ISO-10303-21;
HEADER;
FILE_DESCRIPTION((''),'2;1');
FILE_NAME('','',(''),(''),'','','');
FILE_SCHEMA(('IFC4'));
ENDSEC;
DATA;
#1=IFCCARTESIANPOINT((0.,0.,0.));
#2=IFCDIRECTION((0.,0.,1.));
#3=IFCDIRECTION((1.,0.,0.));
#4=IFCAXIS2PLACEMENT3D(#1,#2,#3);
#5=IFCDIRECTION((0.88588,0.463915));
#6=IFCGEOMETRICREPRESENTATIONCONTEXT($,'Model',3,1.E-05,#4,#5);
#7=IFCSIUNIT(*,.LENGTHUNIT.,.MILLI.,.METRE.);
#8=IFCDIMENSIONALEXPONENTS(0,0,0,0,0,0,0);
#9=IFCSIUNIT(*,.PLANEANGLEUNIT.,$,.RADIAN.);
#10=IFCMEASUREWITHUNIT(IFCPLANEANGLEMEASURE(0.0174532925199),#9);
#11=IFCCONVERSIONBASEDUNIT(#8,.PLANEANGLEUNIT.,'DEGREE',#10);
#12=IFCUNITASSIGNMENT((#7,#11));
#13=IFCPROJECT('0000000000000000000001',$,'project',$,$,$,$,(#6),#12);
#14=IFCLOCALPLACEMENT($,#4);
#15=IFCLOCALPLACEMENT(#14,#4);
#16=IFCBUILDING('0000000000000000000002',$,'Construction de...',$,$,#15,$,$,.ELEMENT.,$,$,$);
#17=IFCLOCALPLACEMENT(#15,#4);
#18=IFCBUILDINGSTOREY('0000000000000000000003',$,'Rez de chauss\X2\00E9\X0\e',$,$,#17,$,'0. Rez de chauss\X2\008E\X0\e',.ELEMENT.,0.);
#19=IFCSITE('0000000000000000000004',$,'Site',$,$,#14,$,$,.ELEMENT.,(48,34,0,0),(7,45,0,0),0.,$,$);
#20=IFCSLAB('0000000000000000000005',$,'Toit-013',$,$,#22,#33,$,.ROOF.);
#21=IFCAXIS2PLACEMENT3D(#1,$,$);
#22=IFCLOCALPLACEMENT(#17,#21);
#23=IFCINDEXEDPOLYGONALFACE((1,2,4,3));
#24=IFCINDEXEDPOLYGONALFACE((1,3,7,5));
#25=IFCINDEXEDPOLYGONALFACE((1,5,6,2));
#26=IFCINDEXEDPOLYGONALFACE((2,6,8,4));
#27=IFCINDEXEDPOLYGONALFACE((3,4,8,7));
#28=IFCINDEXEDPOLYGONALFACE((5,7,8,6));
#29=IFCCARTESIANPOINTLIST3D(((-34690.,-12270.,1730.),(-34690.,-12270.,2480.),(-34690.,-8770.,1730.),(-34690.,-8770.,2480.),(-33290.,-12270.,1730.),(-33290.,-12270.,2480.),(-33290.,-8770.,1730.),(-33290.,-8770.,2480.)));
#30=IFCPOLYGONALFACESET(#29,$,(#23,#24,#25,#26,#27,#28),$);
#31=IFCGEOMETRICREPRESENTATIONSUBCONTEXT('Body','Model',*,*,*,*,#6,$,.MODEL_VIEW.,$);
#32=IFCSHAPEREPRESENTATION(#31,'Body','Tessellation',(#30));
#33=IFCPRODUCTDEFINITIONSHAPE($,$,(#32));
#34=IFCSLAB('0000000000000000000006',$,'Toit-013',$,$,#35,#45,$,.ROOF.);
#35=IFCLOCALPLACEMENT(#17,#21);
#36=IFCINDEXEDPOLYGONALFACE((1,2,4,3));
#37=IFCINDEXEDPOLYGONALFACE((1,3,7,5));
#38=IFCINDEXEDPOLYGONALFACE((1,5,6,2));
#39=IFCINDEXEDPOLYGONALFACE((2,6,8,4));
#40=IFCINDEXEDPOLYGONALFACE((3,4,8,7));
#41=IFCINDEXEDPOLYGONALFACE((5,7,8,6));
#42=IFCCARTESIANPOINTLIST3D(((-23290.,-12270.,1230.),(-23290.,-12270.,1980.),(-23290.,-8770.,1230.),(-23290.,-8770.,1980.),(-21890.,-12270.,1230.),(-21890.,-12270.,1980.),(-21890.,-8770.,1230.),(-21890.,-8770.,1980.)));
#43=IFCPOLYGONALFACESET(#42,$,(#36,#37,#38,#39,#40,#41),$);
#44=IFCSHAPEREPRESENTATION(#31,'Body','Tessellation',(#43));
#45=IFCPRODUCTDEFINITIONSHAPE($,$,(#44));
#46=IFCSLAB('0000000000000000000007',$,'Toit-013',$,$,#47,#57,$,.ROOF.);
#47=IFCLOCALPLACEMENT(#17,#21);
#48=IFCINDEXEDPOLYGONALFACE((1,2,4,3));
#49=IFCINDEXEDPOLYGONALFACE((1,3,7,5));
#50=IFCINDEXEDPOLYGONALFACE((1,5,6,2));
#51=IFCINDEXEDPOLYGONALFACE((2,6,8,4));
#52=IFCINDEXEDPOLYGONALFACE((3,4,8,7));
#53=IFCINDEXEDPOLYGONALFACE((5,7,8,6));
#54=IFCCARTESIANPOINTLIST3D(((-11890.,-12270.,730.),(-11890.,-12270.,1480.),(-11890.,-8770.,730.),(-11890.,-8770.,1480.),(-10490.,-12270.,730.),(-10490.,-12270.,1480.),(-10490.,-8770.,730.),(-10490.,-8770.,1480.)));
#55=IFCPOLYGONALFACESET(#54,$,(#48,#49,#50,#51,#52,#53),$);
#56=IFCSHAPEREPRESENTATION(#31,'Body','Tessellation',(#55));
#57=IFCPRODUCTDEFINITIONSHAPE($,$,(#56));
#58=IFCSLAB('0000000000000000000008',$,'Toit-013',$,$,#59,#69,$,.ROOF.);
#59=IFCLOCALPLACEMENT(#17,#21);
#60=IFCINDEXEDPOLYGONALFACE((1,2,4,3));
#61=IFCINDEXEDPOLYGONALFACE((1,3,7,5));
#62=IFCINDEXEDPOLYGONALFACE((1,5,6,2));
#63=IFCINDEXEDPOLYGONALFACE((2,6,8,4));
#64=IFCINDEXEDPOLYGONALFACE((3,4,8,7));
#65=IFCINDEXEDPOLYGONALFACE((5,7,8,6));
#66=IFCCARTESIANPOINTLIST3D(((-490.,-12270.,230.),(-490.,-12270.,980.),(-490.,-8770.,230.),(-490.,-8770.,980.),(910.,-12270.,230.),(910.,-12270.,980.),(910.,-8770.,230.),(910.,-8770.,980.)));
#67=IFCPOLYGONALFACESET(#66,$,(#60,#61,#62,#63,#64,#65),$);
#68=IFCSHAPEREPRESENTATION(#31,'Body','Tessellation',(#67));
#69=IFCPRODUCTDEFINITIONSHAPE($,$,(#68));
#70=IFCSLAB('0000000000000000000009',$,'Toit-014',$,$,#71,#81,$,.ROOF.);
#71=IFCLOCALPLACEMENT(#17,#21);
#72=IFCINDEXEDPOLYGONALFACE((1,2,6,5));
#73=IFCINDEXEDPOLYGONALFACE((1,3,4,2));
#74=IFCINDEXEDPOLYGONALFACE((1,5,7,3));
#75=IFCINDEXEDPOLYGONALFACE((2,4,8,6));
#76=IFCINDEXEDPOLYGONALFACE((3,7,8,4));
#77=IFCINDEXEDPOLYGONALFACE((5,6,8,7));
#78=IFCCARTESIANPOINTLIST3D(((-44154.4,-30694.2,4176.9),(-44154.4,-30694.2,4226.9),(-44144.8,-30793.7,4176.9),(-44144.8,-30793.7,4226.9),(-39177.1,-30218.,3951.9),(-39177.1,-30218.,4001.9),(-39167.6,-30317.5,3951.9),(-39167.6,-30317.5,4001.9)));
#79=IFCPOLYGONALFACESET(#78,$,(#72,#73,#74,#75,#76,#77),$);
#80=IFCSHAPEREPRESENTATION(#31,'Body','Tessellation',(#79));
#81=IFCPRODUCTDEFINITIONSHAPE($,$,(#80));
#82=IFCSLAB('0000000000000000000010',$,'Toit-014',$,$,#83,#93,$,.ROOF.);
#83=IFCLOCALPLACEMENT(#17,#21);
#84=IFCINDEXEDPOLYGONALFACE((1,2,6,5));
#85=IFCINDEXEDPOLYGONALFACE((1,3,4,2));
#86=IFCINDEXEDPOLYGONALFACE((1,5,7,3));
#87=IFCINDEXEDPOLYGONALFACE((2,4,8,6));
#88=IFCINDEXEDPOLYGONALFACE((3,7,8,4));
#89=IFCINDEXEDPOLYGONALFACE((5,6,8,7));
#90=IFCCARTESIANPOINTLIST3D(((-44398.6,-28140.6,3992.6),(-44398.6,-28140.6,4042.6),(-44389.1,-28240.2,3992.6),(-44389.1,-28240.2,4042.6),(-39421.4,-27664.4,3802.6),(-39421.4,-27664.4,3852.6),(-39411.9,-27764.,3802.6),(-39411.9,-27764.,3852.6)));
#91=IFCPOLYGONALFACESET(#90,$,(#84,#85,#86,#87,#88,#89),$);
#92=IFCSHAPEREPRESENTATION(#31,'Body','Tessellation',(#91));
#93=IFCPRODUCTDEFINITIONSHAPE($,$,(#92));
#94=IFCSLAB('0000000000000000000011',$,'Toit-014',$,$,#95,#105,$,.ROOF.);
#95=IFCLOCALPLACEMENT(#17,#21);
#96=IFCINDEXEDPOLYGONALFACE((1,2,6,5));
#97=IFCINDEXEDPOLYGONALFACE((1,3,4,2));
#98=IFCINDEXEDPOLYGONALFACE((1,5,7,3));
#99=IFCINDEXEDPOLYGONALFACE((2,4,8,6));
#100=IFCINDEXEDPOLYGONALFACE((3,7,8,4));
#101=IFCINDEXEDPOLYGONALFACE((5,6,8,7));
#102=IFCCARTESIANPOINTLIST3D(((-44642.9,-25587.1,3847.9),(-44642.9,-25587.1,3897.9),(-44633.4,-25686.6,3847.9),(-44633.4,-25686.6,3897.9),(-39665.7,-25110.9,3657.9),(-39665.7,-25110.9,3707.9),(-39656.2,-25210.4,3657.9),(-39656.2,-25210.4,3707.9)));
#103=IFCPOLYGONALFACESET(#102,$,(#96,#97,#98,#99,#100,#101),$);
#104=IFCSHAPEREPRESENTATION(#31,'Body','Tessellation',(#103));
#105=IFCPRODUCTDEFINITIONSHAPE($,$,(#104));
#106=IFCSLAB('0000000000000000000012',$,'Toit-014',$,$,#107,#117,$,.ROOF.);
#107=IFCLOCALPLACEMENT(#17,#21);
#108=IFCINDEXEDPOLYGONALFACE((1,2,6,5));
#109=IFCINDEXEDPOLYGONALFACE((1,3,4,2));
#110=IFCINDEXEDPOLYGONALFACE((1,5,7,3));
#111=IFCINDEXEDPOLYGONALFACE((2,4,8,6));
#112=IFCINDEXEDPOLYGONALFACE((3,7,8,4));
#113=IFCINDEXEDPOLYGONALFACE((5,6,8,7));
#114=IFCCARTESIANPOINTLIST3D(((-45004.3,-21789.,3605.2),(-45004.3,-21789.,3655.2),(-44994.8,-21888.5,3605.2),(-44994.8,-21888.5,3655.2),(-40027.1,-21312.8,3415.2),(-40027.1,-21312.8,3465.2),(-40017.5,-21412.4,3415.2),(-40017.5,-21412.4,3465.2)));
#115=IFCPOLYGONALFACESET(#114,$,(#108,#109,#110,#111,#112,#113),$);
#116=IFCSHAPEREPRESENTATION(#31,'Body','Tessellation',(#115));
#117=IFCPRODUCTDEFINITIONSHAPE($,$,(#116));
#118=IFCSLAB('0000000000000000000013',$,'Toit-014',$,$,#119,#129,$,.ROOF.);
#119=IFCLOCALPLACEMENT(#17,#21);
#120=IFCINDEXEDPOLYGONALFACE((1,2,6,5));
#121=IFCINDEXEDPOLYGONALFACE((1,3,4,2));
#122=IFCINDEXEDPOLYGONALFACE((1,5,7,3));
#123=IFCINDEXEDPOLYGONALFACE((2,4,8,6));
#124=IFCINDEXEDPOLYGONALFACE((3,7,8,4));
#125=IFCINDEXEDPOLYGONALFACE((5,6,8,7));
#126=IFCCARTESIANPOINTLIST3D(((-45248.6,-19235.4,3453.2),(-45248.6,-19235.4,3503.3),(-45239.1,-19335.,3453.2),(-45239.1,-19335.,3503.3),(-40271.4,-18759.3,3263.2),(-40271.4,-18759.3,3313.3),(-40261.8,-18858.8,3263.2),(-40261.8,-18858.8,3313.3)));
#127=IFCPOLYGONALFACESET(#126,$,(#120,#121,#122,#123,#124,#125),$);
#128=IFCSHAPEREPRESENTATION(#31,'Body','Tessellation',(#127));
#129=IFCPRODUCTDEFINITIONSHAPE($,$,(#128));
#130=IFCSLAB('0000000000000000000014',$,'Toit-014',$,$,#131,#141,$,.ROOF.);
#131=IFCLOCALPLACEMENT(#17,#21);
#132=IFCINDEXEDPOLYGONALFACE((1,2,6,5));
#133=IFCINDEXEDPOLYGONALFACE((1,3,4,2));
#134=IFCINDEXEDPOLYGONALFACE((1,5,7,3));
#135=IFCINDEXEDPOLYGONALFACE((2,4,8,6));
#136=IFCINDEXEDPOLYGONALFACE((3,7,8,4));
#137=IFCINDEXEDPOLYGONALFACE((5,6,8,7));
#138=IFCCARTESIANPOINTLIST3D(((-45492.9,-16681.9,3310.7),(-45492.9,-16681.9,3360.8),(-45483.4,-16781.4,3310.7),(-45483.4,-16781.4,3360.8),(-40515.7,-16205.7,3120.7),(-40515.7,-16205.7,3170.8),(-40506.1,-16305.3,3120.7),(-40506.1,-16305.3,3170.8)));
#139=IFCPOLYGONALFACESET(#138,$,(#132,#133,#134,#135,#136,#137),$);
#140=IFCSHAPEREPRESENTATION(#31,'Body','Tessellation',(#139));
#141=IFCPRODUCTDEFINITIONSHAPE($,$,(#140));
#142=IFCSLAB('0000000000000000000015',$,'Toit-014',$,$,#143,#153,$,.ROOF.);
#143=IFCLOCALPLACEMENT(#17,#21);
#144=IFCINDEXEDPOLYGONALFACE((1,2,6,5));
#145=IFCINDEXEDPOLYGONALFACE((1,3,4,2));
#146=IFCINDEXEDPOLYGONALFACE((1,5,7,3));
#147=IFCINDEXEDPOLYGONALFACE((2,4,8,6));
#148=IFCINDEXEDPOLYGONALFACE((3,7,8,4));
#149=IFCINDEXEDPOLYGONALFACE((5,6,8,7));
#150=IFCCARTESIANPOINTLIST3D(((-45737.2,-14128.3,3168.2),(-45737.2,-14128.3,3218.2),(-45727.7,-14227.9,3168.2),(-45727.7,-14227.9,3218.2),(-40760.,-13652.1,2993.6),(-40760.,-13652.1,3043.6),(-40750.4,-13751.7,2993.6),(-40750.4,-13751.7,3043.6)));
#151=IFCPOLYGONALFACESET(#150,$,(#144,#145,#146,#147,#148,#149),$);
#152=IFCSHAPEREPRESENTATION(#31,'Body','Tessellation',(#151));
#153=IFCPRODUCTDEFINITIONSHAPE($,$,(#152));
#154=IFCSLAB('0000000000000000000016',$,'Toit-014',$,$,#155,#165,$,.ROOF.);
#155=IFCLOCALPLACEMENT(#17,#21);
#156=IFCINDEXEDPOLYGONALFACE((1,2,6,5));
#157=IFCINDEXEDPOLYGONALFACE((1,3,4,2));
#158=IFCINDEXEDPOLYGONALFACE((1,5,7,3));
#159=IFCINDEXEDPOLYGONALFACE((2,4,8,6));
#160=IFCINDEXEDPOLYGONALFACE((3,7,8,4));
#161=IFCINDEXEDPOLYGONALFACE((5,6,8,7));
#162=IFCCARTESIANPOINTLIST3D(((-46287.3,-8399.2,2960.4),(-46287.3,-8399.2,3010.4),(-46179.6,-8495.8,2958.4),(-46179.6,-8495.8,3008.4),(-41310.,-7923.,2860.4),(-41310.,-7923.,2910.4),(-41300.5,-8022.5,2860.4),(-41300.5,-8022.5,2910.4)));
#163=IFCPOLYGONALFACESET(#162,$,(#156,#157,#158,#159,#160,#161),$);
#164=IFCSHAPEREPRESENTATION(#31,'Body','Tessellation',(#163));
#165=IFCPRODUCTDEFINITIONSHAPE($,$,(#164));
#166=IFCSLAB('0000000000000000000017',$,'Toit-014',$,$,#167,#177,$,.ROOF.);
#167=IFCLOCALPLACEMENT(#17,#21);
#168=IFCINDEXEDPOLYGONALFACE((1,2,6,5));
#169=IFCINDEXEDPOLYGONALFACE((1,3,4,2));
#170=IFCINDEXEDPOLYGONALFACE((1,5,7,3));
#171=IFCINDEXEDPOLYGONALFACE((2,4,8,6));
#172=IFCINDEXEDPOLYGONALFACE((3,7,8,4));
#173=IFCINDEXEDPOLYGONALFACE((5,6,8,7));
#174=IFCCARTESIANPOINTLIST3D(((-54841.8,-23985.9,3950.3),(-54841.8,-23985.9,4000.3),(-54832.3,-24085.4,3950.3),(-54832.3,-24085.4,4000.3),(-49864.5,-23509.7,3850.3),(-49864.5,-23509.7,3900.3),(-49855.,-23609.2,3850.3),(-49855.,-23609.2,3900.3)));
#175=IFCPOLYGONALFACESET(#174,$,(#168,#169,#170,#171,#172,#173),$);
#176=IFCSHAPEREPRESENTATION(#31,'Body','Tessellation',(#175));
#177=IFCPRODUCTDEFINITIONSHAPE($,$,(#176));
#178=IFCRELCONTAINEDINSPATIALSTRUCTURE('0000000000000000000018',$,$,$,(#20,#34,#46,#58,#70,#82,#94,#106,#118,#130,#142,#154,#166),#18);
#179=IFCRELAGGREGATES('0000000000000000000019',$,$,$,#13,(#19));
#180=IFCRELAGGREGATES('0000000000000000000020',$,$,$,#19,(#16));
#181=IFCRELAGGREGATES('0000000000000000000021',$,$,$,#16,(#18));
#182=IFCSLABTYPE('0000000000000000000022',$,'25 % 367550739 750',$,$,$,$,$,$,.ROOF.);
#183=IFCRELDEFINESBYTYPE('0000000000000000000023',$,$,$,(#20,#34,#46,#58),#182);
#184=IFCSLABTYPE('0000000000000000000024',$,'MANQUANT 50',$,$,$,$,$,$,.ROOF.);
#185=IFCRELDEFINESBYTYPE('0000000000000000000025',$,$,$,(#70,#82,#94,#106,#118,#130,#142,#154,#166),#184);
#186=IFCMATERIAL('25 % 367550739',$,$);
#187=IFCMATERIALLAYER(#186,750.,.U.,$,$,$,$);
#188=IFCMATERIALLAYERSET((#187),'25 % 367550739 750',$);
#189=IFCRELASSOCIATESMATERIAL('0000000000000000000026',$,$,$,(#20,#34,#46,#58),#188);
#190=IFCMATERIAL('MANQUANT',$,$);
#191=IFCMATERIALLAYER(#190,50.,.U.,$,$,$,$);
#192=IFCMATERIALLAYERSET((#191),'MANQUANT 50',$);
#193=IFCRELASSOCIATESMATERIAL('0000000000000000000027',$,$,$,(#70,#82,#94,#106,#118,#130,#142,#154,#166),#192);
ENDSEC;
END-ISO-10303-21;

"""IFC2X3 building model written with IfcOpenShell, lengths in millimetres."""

from ifc_helpers import new_model, entity, si_unit, converted_unit, direction, frame, origin_with_axes, place, context, subcontext, project, spatial, polyline, outline, extrude, material, layer, layer_set, layer_usage, type_object, element, save


model = new_model("IFC2X3")

# Units and contexts
model_context = context("Model", 3, precision=1e-05, world=origin_with_axes(), true_north=direction((0.88588, 0.463915)))
body_context = subcontext(model_context, "Body", "Model", "MODEL_VIEW")
ifc_project = project(units=[si_unit("LENGTHUNIT", "METRE", prefix="MILLI"), converted_unit("PLANEANGLEUNIT", "DEGREE", entity("IfcPlaneAngleMeasure", 0.0174532925199), si_unit("PLANEANGLEUNIT", "RADIAN"), dimensions=[0, 0, 0, 0, 0, 0, 0])], contexts=[model_context])

# Site, building, storey
site_placement = place(None, origin_with_axes())
site = spatial("IfcSite", under=ifc_project, at=site_placement, Name="Site", CompositionType="ELEMENT", RefLatitude=(48, 34, 0, 0), RefLongitude=(7, 45, 0, 0), RefElevation=0.0)
building_placement = place(site_placement, origin_with_axes())
building = spatial("IfcBuilding", under=site, at=building_placement, Name="Construction de...", CompositionType="ELEMENT")
storey_placement = place(building_placement, origin_with_axes())
storey = spatial("IfcBuildingStorey", under=building, at=storey_placement, Name="Rez de chaussée", LongName="0. Rez de chauss\u008ee", CompositionType="ELEMENT", Elevation=0.0)

# Slabs
ifc_material_1 = material(Name="25 % 367550739")
ifc_layer_1 = layer(ifc_material_1, 750.0, ventilated="UNKNOWN")
ifc_layer_set_1 = layer_set([ifc_layer_1], Name="25 % 367550739 750")
ifc_layer_usage_1 = layer_usage(ifc_layer_set_1, "AXIS3", "NEGATIVE", 750.0)
slab_type_1 = type_object("IfcSlabType", Name="25 % 367550739 750", PredefinedType="ROOF")
slab_1_placement = place(storey_placement, frame((-33290.0, -8770.0, 1730.0), z_axis=(0.0, 0.0, 1.0), x_axis=(0.0, -1.0, 0.0)))
element("IfcSlab", 1, at=slab_1_placement, inside=storey, type_object=slab_type_1, material=ifc_layer_usage_1, Name="Toit-013", PredefinedType="ROOF", context=body_context, shape_type="SweptSolid", body=[
    extrude(outline(polyline([(0.0, -1400.0), (3500.0, -1400.0), (3500.0, 0.0), (0.0, 0.0), (0.0, -1400.0)])), origin_with_axes(), (0.0, 0.0, 1.0), 750.0),
])
ifc_layer_usage_2 = layer_usage(ifc_layer_set_1, "AXIS3", "NEGATIVE", 750.0)
slab_2_placement = place(storey_placement, frame((-21890.0, -8770.0, 1230.0), z_axis=(0.0, 0.0, 1.0), x_axis=(0.0, -1.0, 0.0)))
element("IfcSlab", 2, at=slab_2_placement, inside=storey, type_object=slab_type_1, material=ifc_layer_usage_2, Name="Toit-013", PredefinedType="ROOF", context=body_context, shape_type="SweptSolid", body=[
    extrude(outline(polyline([(0.0, -1400.0), (3500.0, -1400.0), (3500.0, 0.0), (0.0, 0.0), (0.0, -1400.0)])), origin_with_axes(), (0.0, 0.0, 1.0), 750.0),
])
ifc_layer_usage_3 = layer_usage(ifc_layer_set_1, "AXIS3", "NEGATIVE", 750.0)
slab_3_placement = place(storey_placement, frame((-10490.0, -8770.0, 730.0), z_axis=(0.0, 0.0, 1.0), x_axis=(0.0, -1.0, 0.0)))
element("IfcSlab", 3, at=slab_3_placement, inside=storey, type_object=slab_type_1, material=ifc_layer_usage_3, Name="Toit-013", PredefinedType="ROOF", context=body_context, shape_type="SweptSolid", body=[
    extrude(outline(polyline([(0.0, -1400.0), (3500.0, -1400.0), (3500.0, 0.0), (0.0, 0.0), (0.0, -1400.0)])), origin_with_axes(), (0.0, 0.0, 1.0), 750.0),
])
ifc_layer_usage_4 = layer_usage(ifc_layer_set_1, "AXIS3", "NEGATIVE", 750.0)
slab_4_placement = place(storey_placement, frame((910.0, -8770.0, 230.0), z_axis=(0.0, 0.0, 1.0), x_axis=(0.0, -1.0, 0.0)))
element("IfcSlab", 4, at=slab_4_placement, inside=storey, type_object=slab_type_1, material=ifc_layer_usage_4, Name="Toit-013", PredefinedType="ROOF", context=body_context, shape_type="SweptSolid", body=[
    extrude(outline(polyline([(0.0, -1400.0), (3500.0, -1400.0), (3500.0, 0.0), (0.0, 0.0), (0.0, -1400.0)])), origin_with_axes(), (0.0, 0.0, 1.0), 750.0),
])
ifc_material_2 = material(Name="MANQUANT")
ifc_layer_2 = layer(ifc_material_2, 50.0, ventilated="UNKNOWN")
ifc_layer_set_2 = layer_set([ifc_layer_2], Name="MANQUANT 50")
ifc_layer_usage_5 = layer_usage(ifc_layer_set_2, "AXIS3", "NEGATIVE", 50.0)
slab_type_2 = type_object("IfcSlabType", Name="MANQUANT 50", PredefinedType="ROOF")
slab_5_placement = place(storey_placement, frame((-39167.6, -30317.5, 3951.9), z_axis=(0.0, 0.0, 1.0), x_axis=(-0.095235, 0.995455, 0.0)))
element("IfcSlab", 5, at=slab_5_placement, inside=storey, type_object=slab_type_2, material=ifc_layer_usage_5, Name="Toit-014", PredefinedType="ROOF", context=body_context, shape_type="SweptSolid", body=[
    extrude(outline(polyline([(0.0, 0.0), (100.0, 0.0), (100.0, 5005.1), (0.0, 5005.1), (0.0, 0.0)])), frame((0.0, 0.0, 0.0), z_axis=(0.0, -0.044955, 0.998989), x_axis=(1.0, 0.0, 0.0)), (0.0, 0.044955, 0.998989), 50.1),
])
ifc_layer_usage_6 = layer_usage(ifc_layer_set_2, "AXIS3", "NEGATIVE", 50.0)
slab_6_placement = place(storey_placement, frame((-39411.9, -27764.0, 3802.6), z_axis=(0.0, 0.0, 1.0), x_axis=(-0.095235, 0.995455, 0.0)))
element("IfcSlab", 6, at=slab_6_placement, inside=storey, type_object=slab_type_2, material=ifc_layer_usage_6, Name="Toit-014", PredefinedType="ROOF", context=body_context, shape_type="SweptSolid", body=[
    extrude(outline(polyline([(0.0, 0.0), (100.0, 0.0), (100.0, 5003.6), (0.0, 5003.6), (0.0, 0.0)])), frame((0.0, 0.0, 0.0), z_axis=(0.0, -0.037973, 0.999279), x_axis=(1.0, 0.0, 0.0)), (0.0, 0.037973, 0.999279), 50.0),
])
ifc_layer_usage_7 = layer_usage(ifc_layer_set_2, "AXIS3", "NEGATIVE", 50.0)
slab_7_placement = place(storey_placement, frame((-39656.2, -25210.4, 3657.9), z_axis=(0.0, 0.0, 1.0), x_axis=(-0.095235, 0.995455, 0.0)))
element("IfcSlab", 7, at=slab_7_placement, inside=storey, type_object=slab_type_2, material=ifc_layer_usage_7, Name="Toit-014", PredefinedType="ROOF", context=body_context, shape_type="SweptSolid", body=[
    extrude(outline(polyline([(0.0, 0.0), (100.0, 0.0), (100.0, 5003.6), (0.0, 5003.6), (0.0, 0.0)])), frame((0.0, 0.0, 0.0), z_axis=(0.0, -0.037973, 0.999279), x_axis=(1.0, 0.0, 0.0)), (0.0, 0.037973, 0.999279), 50.0),
])
ifc_layer_usage_8 = layer_usage(ifc_layer_set_2, "AXIS3", "NEGATIVE", 50.0)
slab_8_placement = place(storey_placement, frame((-40017.5, -21412.4, 3415.2), z_axis=(0.0, 0.0, 1.0), x_axis=(-0.095235, 0.995455, 0.0)))
element("IfcSlab", 8, at=slab_8_placement, inside=storey, type_object=slab_type_2, material=ifc_layer_usage_8, Name="Toit-014", PredefinedType="ROOF", context=body_context, shape_type="SweptSolid", body=[
    extrude(outline(polyline([(0.0, 0.0), (100.0, 0.0), (100.0, 5003.6), (0.0, 5003.6), (0.0, 0.0)])), frame((0.0, 0.0, 0.0), z_axis=(0.0, -0.037973, 0.999279), x_axis=(1.0, 0.0, 0.0)), (0.0, 0.037973, 0.999279), 50.0),
])
ifc_layer_usage_9 = layer_usage(ifc_layer_set_2, "AXIS3", "NEGATIVE", 50.0)
slab_9_placement = place(storey_placement, frame((-40261.8, -18858.8, 3263.2), z_axis=(0.0, 0.0, 1.0), x_axis=(-0.095235, 0.995455, 0.0)))
element("IfcSlab", 9, at=slab_9_placement, inside=storey, type_object=slab_type_2, material=ifc_layer_usage_9, Name="Toit-014", PredefinedType="ROOF", context=body_context, shape_type="SweptSolid", body=[
    extrude(outline(polyline([(0.0, 0.0), (100.0, 0.0), (100.0, 5003.6), (0.0, 5003.6), (0.0, 0.0)])), frame((0.0, 0.0, 0.0), z_axis=(0.0, -0.037973, 0.999279), x_axis=(1.0, 0.0, 0.0)), (0.0, 0.037973, 0.999279), 50.0),
])
ifc_layer_usage_10 = layer_usage(ifc_layer_set_2, "AXIS3", "NEGATIVE", 50.0)
slab_10_placement = place(storey_placement, frame((-40506.1, -16305.3, 3120.7), z_axis=(0.0, 0.0, 1.0), x_axis=(-0.095235, 0.995455, 0.0)))
element("IfcSlab", 10, at=slab_10_placement, inside=storey, type_object=slab_type_2, material=ifc_layer_usage_10, Name="Toit-014", PredefinedType="ROOF", context=body_context, shape_type="SweptSolid", body=[
    extrude(outline(polyline([(0.0, 0.0), (100.0, 0.0), (100.0, 5003.6), (0.0, 5003.6), (0.0, 0.0)])), frame((0.0, 0.0, 0.0), z_axis=(0.0, -0.037973, 0.999279), x_axis=(1.0, 0.0, 0.0)), (0.0, 0.037973, 0.999279), 50.0),
])
ifc_layer_usage_11 = layer_usage(ifc_layer_set_2, "AXIS3", "NEGATIVE", 50.0)
slab_11_placement = place(storey_placement, frame((-40750.4, -13751.7, 2993.6), z_axis=(0.0, 0.0, 1.0), x_axis=(-0.095235, 0.995455, 0.0)))
element("IfcSlab", 11, at=slab_11_placement, inside=storey, type_object=slab_type_2, material=ifc_layer_usage_11, Name="Toit-014", PredefinedType="ROOF", context=body_context, shape_type="SweptSolid", body=[
    extrude(outline(polyline([(0.0, 0.0), (100.0, 0.0), (100.0, 5003.0), (0.0, 5003.0), (0.0, 0.0)])), frame((0.0, 0.0, 0.0), z_axis=(0.0, -0.034899, 0.999391), x_axis=(1.0, 0.0, 0.0)), (0.0, 0.034899, 0.999391), 50.0),
])
ifc_layer_usage_12 = layer_usage(ifc_layer_set_2, "AXIS3", "NEGATIVE", 50.0)
slab_12_placement = place(storey_placement, frame((-41300.5, -8022.5, 2860.4), z_axis=(0.0, 0.0, 1.0), x_axis=(-0.095235, 0.995455, 0.0)))
element("IfcSlab", 12, at=slab_12_placement, inside=storey, type_object=slab_type_2, material=ifc_layer_usage_12, Name="Toit-014", PredefinedType="ROOF", context=body_context, shape_type="SweptSolid", body=[
    extrude(outline(polyline([(0.0, 0.0), (100.0, 0.0), (100.0, 5001.0), (-6.4, 4902.9), (0.0, 0.0)])), frame((0.0, 0.0, 0.0), z_axis=(0.0, -0.019996, 0.9998), x_axis=(1.0, 0.0, 0.0)), (0.0, 0.019996, 0.9998), 50.0),
])
ifc_layer_usage_13 = layer_usage(ifc_layer_set_2, "AXIS3", "NEGATIVE", 50.0)
slab_13_placement = place(storey_placement, frame((-49855.0, -23609.2, 3850.3), z_axis=(0.0, 0.0, 1.0), x_axis=(-0.095235, 0.995455, 0.0)))
element("IfcSlab", 13, at=slab_13_placement, inside=storey, type_object=slab_type_2, material=ifc_layer_usage_13, Name="Toit-014", PredefinedType="ROOF", context=body_context, shape_type="SweptSolid", body=[
    extrude(outline(polyline([(0.0, 0.0), (100.0, 0.0), (100.0, 5001.0), (0.0, 5001.0), (0.0, 0.0)])), frame((0.0, 0.0, 0.0), z_axis=(0.0, -0.019996, 0.9998), x_axis=(1.0, 0.0, 0.0)), (0.0, 0.019996, 0.9998), 50.0),
])

save(model, "model.ifc")
